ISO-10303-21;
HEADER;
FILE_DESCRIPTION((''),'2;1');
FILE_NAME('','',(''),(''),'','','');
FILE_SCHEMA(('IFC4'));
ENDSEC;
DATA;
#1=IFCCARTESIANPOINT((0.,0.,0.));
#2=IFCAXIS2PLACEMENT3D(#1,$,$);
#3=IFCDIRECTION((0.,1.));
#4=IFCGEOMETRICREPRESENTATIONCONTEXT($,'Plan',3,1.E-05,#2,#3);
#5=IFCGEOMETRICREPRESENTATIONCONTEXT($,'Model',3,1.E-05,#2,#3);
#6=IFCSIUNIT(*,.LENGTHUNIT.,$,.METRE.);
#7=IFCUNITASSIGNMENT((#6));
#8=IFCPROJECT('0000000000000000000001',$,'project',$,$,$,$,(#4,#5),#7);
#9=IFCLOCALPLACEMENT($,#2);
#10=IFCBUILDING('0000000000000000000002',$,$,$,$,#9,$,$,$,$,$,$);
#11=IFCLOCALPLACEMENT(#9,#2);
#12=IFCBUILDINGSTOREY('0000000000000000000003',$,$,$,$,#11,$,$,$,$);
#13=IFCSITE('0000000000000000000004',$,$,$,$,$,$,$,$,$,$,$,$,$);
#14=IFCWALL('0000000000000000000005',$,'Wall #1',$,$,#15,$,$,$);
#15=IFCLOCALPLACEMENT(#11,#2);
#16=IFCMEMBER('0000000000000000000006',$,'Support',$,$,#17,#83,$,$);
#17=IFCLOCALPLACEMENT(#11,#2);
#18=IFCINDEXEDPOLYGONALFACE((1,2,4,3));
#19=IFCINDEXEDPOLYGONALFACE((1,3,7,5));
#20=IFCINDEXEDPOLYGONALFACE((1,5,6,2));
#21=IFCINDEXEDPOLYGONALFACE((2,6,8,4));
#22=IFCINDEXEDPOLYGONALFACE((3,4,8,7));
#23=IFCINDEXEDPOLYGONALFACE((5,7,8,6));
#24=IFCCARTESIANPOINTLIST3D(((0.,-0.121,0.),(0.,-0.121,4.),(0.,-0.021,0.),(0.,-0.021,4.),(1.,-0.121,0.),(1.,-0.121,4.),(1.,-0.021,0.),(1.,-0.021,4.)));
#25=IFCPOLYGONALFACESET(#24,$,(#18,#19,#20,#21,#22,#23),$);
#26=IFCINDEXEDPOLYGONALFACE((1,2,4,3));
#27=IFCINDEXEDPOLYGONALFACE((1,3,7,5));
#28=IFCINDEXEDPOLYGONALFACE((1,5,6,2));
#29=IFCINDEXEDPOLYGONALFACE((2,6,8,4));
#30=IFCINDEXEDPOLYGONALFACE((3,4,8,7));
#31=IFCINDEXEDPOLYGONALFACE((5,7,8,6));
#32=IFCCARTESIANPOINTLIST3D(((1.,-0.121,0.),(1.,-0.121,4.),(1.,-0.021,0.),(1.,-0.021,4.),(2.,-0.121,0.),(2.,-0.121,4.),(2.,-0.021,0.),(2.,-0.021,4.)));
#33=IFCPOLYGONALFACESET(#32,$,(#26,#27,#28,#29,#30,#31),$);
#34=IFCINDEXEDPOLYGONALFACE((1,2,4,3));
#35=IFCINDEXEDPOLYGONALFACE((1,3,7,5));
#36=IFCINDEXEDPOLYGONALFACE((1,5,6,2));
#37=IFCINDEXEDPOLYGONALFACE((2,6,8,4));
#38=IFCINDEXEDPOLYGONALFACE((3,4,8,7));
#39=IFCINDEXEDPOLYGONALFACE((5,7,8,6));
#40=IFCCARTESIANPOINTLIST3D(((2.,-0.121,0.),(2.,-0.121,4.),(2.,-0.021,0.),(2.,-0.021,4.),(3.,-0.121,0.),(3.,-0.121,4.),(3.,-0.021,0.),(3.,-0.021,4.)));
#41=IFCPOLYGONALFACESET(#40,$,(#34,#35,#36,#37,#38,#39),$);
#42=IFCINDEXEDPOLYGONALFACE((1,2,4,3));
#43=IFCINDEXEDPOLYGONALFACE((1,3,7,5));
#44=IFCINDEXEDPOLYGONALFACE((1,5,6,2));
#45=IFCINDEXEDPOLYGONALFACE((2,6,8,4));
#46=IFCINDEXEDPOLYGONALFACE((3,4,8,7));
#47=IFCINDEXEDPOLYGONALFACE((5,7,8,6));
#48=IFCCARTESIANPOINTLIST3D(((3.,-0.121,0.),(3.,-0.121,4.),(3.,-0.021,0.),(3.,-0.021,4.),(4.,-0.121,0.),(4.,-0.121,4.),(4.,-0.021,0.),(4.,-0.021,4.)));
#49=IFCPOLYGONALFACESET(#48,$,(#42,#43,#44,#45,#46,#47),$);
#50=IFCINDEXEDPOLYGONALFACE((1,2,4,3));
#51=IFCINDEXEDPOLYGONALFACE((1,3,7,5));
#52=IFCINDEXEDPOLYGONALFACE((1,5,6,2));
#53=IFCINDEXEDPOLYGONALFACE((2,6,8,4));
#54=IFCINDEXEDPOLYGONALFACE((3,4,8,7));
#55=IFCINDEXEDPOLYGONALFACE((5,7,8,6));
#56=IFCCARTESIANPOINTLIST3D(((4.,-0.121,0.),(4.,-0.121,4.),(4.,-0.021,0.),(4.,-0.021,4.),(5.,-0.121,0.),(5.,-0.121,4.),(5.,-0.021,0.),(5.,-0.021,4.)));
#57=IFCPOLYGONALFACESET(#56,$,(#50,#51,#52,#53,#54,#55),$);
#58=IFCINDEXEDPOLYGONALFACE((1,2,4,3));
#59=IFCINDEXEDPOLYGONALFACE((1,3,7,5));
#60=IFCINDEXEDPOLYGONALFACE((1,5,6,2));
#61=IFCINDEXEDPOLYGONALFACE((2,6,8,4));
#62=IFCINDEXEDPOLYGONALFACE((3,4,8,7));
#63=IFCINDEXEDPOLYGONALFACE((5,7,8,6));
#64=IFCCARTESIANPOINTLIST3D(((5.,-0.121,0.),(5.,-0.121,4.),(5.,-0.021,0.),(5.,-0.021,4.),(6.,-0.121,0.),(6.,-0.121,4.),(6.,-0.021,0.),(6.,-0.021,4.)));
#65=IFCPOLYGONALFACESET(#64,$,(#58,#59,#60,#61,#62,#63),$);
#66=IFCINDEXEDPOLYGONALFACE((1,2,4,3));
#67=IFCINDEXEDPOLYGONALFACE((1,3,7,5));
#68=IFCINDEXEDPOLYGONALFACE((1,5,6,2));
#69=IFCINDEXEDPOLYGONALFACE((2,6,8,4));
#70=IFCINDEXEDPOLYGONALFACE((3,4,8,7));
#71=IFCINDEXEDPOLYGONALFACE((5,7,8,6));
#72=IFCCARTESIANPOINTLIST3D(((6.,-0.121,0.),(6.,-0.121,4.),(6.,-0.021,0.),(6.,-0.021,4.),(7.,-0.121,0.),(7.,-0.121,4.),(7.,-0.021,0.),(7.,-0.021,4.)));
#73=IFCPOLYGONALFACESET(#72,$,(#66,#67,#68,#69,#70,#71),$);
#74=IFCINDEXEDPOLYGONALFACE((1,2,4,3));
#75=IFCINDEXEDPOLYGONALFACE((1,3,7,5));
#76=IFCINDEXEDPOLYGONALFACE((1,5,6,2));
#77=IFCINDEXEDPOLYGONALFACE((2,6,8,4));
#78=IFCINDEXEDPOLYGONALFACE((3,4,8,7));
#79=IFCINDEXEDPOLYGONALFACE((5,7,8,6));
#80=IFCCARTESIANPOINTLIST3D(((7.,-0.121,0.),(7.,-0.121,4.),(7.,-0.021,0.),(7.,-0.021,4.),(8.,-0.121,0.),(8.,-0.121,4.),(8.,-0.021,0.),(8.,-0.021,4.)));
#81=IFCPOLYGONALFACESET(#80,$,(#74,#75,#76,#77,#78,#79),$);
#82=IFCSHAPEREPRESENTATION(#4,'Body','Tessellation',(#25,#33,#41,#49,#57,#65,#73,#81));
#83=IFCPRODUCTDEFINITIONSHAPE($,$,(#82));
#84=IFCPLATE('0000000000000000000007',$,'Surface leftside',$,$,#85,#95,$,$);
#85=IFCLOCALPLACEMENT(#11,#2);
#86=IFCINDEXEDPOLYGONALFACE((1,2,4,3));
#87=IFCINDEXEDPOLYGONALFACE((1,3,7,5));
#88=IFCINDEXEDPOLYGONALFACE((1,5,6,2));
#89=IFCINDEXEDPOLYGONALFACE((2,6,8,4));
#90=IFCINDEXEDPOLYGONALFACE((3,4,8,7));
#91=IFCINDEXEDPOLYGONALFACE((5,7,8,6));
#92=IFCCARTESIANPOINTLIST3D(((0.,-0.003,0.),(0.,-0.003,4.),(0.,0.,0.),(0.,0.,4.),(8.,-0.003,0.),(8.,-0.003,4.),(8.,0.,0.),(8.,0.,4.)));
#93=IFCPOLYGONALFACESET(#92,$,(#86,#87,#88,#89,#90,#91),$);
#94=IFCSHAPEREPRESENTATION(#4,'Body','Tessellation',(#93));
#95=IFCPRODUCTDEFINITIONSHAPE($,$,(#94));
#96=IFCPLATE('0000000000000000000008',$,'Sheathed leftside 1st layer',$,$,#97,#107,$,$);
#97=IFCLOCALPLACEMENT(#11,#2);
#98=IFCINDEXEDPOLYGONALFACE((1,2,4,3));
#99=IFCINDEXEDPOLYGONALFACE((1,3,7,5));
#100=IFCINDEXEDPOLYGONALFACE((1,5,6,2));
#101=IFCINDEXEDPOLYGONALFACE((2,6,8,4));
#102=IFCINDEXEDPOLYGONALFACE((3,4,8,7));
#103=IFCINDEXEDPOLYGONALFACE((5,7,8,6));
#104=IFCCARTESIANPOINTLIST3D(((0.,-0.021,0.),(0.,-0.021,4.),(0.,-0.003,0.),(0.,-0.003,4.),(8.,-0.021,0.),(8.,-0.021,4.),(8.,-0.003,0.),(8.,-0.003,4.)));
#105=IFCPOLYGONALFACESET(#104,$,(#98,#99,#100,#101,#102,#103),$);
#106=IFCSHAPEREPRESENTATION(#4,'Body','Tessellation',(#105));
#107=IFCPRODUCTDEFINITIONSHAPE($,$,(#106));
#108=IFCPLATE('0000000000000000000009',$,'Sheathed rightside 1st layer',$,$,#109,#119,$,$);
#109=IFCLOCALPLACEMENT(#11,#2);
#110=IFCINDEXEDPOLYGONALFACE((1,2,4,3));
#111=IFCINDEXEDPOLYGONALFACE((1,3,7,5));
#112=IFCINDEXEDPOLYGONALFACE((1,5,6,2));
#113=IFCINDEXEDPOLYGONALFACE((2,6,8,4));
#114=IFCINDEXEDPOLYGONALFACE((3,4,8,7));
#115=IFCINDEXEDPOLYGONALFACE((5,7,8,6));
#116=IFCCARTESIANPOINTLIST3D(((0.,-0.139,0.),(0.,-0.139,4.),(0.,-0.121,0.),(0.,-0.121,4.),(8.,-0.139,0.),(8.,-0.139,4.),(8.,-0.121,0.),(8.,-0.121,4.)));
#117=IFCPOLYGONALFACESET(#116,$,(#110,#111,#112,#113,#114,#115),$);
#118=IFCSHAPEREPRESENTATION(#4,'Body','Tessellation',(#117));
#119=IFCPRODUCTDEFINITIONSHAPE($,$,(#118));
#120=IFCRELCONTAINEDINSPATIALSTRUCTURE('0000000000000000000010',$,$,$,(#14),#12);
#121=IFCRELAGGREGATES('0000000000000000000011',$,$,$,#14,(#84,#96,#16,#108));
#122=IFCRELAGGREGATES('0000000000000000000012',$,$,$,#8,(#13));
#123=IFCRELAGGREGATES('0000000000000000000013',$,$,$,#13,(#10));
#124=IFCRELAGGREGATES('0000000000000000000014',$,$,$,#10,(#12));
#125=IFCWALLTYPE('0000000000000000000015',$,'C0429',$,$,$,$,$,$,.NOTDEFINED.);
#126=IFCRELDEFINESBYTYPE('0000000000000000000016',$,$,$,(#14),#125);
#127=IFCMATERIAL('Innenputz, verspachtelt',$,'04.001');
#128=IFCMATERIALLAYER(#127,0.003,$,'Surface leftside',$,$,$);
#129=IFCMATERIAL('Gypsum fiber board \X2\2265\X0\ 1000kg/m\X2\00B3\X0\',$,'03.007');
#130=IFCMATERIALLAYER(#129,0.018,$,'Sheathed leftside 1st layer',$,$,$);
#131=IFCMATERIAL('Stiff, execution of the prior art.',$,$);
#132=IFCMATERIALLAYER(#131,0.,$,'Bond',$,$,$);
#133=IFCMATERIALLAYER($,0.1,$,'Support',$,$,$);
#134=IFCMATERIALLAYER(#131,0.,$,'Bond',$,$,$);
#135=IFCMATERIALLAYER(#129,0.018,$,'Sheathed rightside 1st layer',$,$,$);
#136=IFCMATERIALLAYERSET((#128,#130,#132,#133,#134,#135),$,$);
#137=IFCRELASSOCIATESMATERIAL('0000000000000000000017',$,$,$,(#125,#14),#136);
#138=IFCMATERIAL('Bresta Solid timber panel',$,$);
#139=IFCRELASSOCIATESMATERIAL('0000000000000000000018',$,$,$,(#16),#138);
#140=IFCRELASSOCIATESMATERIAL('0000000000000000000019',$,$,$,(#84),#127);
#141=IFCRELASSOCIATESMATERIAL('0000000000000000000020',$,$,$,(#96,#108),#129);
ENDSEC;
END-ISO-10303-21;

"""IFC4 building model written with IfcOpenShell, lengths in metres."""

from ifc_helpers import new_model, si_unit, direction, frame, frame_2d, origin, origin_with_axes, place, context, project, spatial, rectangle, extrude, material, layer, layer_set, type_object, element, aggregate, save


model = new_model("IFC4")

# Units and contexts
plan_context = context("Plan", 3, precision=1e-05, world=origin(), true_north=direction((0.0, 1.0)))
model_context = context("Model", 3, precision=1e-05, world=origin(), true_north=direction((0.0, 1.0)))
ifc_project = project(units=[si_unit("LENGTHUNIT", "METRE")], contexts=[plan_context, model_context])

# Site, building, storey
site = spatial("IfcSite", under=ifc_project)
building_placement = place(None, origin())
building = spatial("IfcBuilding", under=site, at=building_placement)
storey_placement = place(building_placement, origin())
storey = spatial("IfcBuildingStorey", under=building, at=storey_placement)

# Wall, member, plates
ifc_material_1 = material(Name="Innenputz, verspachtelt", Category="04.001")
ifc_layer_1 = layer(ifc_material_1, 0.003, Name="Surface leftside")
ifc_material_2 = material(Name="Gypsum fiber board ≥ 1000kg/m³", Category="03.007")
ifc_layer_2 = layer(ifc_material_2, 0.018, Name="Sheathed leftside 1st layer")
ifc_material_3 = material(Name="Stiff, execution of the prior art.")
ifc_layer_3 = layer(ifc_material_3, 0.0, Name="Bond")
ifc_layer_4 = layer(None, 0.1, Name="Support")
ifc_layer_5 = layer(ifc_material_3, 0.0, Name="Bond")
ifc_layer_6 = layer(ifc_material_2, 0.018, Name="Sheathed rightside 1st layer")
ifc_layer_set = layer_set([ifc_layer_1, ifc_layer_2, ifc_layer_3, ifc_layer_4, ifc_layer_5, ifc_layer_6])
wall_type = type_object("IfcWallType", Name="C0429", PredefinedType="NOTDEFINED", material=ifc_layer_set)
wall_placement = place(None, frame((0.0, 0.0, 0.0), z_axis=(0.0, -1.0, 0.0), x_axis=(1.0, 0.0, 0.0)))
wall = element("IfcWall", 1, at=wall_placement, inside=storey, type_object=wall_type, material=ifc_layer_set, Name="Wall #1")
ifc_material_4 = material(Name="Bresta Solid timber panel")
member_placement = place(wall_placement, origin())
member = element("IfcMember", 2, at=member_placement, material=ifc_material_4, Name="Support", context=plan_context, shape_type="SweptSolid", body=[
    extrude(rectangle(XDim=1.0, YDim=0.1, at=frame_2d((0.5, 0.05), x_axis=(1.0, 0.0))), frame((0.0, 4.0, 0.021), z_axis=(0.0, -1.0, 0.0), x_axis=(1.0, 0.0, 0.0)), (0.0, 0.0, 1.0), 4.0),
    extrude(rectangle(XDim=1.0, YDim=0.1, at=frame_2d((0.5, 0.05), x_axis=(1.0, 0.0))), frame((1.0, 4.0, 0.021), z_axis=(0.0, -1.0, 0.0), x_axis=(1.0, 0.0, 0.0)), (0.0, 0.0, 1.0), 4.0),
    extrude(rectangle(XDim=1.0, YDim=0.1, at=frame_2d((0.5, 0.05), x_axis=(1.0, 0.0))), frame((2.0, 4.0, 0.021), z_axis=(0.0, -1.0, 0.0), x_axis=(1.0, 0.0, 0.0)), (0.0, 0.0, 1.0), 4.0),
    extrude(rectangle(XDim=1.0, YDim=0.1, at=frame_2d((0.5, 0.05), x_axis=(1.0, 0.0))), frame((3.0, 4.0, 0.021), z_axis=(0.0, -1.0, 0.0), x_axis=(1.0, 0.0, 0.0)), (0.0, 0.0, 1.0), 4.0),
    extrude(rectangle(XDim=1.0, YDim=0.1, at=frame_2d((0.5, 0.05), x_axis=(1.0, 0.0))), frame((4.0, 4.0, 0.021), z_axis=(0.0, -1.0, 0.0), x_axis=(1.0, 0.0, 0.0)), (0.0, 0.0, 1.0), 4.0),
    extrude(rectangle(XDim=1.0, YDim=0.1, at=frame_2d((0.5, 0.05), x_axis=(1.0, 0.0))), frame((5.0, 4.0, 0.021), z_axis=(0.0, -1.0, 0.0), x_axis=(1.0, 0.0, 0.0)), (0.0, 0.0, 1.0), 4.0),
    extrude(rectangle(XDim=1.0, YDim=0.1, at=frame_2d((0.5, 0.05), x_axis=(1.0, 0.0))), frame((6.0, 4.0, 0.021), z_axis=(0.0, -1.0, 0.0), x_axis=(1.0, 0.0, 0.0)), (0.0, 0.0, 1.0), 4.0),
    extrude(rectangle(XDim=1.0, YDim=0.1, at=frame_2d((0.5, 0.05), x_axis=(1.0, 0.0))), frame((7.0, 4.0, 0.021), z_axis=(0.0, -1.0, 0.0), x_axis=(1.0, 0.0, 0.0)), (0.0, 0.0, 1.0), 4.0),
])
plate_1_placement = place(wall_placement, origin())
plate_1 = element("IfcPlate", 3, at=plate_1_placement, material=ifc_material_1, Name="Surface leftside", context=plan_context, shape_type="SweptSolid", body=[
    extrude(rectangle(XDim=8.0, YDim=4.0, at=frame_2d((4.0, 2.0), x_axis=(1.0, 0.0))), origin_with_axes(), (0.0, 0.0, 1.0), 0.003),
])
plate_2_placement = place(wall_placement, origin())
plate_2 = element("IfcPlate", 4, at=plate_2_placement, material=ifc_material_2, Name="Sheathed leftside 1st layer", context=plan_context, shape_type="SweptSolid", body=[
    extrude(rectangle(XDim=8.0, YDim=4.0, at=frame_2d((4.0, 2.0), x_axis=(1.0, 0.0))), frame((0.0, 0.0, 0.003), z_axis=(0.0, 0.0, 1.0), x_axis=(1.0, 0.0, 0.0)), (0.0, 0.0, 1.0), 0.018),
])
plate_3_placement = place(wall_placement, origin())
plate_3 = element("IfcPlate", 5, at=plate_3_placement, material=ifc_material_2, Name="Sheathed rightside 1st layer", context=plan_context, shape_type="SweptSolid", body=[
    extrude(rectangle(XDim=8.0, YDim=4.0, at=frame_2d((4.0, 2.0), x_axis=(1.0, 0.0))), frame((0.0, 0.0, 0.121), z_axis=(0.0, 0.0, 1.0), x_axis=(1.0, 0.0, 0.0)), (0.0, 0.0, 1.0), 0.018),
])
aggregate(wall, [plate_1, plate_2, member, plate_3])

save(model, "model.ifc")
